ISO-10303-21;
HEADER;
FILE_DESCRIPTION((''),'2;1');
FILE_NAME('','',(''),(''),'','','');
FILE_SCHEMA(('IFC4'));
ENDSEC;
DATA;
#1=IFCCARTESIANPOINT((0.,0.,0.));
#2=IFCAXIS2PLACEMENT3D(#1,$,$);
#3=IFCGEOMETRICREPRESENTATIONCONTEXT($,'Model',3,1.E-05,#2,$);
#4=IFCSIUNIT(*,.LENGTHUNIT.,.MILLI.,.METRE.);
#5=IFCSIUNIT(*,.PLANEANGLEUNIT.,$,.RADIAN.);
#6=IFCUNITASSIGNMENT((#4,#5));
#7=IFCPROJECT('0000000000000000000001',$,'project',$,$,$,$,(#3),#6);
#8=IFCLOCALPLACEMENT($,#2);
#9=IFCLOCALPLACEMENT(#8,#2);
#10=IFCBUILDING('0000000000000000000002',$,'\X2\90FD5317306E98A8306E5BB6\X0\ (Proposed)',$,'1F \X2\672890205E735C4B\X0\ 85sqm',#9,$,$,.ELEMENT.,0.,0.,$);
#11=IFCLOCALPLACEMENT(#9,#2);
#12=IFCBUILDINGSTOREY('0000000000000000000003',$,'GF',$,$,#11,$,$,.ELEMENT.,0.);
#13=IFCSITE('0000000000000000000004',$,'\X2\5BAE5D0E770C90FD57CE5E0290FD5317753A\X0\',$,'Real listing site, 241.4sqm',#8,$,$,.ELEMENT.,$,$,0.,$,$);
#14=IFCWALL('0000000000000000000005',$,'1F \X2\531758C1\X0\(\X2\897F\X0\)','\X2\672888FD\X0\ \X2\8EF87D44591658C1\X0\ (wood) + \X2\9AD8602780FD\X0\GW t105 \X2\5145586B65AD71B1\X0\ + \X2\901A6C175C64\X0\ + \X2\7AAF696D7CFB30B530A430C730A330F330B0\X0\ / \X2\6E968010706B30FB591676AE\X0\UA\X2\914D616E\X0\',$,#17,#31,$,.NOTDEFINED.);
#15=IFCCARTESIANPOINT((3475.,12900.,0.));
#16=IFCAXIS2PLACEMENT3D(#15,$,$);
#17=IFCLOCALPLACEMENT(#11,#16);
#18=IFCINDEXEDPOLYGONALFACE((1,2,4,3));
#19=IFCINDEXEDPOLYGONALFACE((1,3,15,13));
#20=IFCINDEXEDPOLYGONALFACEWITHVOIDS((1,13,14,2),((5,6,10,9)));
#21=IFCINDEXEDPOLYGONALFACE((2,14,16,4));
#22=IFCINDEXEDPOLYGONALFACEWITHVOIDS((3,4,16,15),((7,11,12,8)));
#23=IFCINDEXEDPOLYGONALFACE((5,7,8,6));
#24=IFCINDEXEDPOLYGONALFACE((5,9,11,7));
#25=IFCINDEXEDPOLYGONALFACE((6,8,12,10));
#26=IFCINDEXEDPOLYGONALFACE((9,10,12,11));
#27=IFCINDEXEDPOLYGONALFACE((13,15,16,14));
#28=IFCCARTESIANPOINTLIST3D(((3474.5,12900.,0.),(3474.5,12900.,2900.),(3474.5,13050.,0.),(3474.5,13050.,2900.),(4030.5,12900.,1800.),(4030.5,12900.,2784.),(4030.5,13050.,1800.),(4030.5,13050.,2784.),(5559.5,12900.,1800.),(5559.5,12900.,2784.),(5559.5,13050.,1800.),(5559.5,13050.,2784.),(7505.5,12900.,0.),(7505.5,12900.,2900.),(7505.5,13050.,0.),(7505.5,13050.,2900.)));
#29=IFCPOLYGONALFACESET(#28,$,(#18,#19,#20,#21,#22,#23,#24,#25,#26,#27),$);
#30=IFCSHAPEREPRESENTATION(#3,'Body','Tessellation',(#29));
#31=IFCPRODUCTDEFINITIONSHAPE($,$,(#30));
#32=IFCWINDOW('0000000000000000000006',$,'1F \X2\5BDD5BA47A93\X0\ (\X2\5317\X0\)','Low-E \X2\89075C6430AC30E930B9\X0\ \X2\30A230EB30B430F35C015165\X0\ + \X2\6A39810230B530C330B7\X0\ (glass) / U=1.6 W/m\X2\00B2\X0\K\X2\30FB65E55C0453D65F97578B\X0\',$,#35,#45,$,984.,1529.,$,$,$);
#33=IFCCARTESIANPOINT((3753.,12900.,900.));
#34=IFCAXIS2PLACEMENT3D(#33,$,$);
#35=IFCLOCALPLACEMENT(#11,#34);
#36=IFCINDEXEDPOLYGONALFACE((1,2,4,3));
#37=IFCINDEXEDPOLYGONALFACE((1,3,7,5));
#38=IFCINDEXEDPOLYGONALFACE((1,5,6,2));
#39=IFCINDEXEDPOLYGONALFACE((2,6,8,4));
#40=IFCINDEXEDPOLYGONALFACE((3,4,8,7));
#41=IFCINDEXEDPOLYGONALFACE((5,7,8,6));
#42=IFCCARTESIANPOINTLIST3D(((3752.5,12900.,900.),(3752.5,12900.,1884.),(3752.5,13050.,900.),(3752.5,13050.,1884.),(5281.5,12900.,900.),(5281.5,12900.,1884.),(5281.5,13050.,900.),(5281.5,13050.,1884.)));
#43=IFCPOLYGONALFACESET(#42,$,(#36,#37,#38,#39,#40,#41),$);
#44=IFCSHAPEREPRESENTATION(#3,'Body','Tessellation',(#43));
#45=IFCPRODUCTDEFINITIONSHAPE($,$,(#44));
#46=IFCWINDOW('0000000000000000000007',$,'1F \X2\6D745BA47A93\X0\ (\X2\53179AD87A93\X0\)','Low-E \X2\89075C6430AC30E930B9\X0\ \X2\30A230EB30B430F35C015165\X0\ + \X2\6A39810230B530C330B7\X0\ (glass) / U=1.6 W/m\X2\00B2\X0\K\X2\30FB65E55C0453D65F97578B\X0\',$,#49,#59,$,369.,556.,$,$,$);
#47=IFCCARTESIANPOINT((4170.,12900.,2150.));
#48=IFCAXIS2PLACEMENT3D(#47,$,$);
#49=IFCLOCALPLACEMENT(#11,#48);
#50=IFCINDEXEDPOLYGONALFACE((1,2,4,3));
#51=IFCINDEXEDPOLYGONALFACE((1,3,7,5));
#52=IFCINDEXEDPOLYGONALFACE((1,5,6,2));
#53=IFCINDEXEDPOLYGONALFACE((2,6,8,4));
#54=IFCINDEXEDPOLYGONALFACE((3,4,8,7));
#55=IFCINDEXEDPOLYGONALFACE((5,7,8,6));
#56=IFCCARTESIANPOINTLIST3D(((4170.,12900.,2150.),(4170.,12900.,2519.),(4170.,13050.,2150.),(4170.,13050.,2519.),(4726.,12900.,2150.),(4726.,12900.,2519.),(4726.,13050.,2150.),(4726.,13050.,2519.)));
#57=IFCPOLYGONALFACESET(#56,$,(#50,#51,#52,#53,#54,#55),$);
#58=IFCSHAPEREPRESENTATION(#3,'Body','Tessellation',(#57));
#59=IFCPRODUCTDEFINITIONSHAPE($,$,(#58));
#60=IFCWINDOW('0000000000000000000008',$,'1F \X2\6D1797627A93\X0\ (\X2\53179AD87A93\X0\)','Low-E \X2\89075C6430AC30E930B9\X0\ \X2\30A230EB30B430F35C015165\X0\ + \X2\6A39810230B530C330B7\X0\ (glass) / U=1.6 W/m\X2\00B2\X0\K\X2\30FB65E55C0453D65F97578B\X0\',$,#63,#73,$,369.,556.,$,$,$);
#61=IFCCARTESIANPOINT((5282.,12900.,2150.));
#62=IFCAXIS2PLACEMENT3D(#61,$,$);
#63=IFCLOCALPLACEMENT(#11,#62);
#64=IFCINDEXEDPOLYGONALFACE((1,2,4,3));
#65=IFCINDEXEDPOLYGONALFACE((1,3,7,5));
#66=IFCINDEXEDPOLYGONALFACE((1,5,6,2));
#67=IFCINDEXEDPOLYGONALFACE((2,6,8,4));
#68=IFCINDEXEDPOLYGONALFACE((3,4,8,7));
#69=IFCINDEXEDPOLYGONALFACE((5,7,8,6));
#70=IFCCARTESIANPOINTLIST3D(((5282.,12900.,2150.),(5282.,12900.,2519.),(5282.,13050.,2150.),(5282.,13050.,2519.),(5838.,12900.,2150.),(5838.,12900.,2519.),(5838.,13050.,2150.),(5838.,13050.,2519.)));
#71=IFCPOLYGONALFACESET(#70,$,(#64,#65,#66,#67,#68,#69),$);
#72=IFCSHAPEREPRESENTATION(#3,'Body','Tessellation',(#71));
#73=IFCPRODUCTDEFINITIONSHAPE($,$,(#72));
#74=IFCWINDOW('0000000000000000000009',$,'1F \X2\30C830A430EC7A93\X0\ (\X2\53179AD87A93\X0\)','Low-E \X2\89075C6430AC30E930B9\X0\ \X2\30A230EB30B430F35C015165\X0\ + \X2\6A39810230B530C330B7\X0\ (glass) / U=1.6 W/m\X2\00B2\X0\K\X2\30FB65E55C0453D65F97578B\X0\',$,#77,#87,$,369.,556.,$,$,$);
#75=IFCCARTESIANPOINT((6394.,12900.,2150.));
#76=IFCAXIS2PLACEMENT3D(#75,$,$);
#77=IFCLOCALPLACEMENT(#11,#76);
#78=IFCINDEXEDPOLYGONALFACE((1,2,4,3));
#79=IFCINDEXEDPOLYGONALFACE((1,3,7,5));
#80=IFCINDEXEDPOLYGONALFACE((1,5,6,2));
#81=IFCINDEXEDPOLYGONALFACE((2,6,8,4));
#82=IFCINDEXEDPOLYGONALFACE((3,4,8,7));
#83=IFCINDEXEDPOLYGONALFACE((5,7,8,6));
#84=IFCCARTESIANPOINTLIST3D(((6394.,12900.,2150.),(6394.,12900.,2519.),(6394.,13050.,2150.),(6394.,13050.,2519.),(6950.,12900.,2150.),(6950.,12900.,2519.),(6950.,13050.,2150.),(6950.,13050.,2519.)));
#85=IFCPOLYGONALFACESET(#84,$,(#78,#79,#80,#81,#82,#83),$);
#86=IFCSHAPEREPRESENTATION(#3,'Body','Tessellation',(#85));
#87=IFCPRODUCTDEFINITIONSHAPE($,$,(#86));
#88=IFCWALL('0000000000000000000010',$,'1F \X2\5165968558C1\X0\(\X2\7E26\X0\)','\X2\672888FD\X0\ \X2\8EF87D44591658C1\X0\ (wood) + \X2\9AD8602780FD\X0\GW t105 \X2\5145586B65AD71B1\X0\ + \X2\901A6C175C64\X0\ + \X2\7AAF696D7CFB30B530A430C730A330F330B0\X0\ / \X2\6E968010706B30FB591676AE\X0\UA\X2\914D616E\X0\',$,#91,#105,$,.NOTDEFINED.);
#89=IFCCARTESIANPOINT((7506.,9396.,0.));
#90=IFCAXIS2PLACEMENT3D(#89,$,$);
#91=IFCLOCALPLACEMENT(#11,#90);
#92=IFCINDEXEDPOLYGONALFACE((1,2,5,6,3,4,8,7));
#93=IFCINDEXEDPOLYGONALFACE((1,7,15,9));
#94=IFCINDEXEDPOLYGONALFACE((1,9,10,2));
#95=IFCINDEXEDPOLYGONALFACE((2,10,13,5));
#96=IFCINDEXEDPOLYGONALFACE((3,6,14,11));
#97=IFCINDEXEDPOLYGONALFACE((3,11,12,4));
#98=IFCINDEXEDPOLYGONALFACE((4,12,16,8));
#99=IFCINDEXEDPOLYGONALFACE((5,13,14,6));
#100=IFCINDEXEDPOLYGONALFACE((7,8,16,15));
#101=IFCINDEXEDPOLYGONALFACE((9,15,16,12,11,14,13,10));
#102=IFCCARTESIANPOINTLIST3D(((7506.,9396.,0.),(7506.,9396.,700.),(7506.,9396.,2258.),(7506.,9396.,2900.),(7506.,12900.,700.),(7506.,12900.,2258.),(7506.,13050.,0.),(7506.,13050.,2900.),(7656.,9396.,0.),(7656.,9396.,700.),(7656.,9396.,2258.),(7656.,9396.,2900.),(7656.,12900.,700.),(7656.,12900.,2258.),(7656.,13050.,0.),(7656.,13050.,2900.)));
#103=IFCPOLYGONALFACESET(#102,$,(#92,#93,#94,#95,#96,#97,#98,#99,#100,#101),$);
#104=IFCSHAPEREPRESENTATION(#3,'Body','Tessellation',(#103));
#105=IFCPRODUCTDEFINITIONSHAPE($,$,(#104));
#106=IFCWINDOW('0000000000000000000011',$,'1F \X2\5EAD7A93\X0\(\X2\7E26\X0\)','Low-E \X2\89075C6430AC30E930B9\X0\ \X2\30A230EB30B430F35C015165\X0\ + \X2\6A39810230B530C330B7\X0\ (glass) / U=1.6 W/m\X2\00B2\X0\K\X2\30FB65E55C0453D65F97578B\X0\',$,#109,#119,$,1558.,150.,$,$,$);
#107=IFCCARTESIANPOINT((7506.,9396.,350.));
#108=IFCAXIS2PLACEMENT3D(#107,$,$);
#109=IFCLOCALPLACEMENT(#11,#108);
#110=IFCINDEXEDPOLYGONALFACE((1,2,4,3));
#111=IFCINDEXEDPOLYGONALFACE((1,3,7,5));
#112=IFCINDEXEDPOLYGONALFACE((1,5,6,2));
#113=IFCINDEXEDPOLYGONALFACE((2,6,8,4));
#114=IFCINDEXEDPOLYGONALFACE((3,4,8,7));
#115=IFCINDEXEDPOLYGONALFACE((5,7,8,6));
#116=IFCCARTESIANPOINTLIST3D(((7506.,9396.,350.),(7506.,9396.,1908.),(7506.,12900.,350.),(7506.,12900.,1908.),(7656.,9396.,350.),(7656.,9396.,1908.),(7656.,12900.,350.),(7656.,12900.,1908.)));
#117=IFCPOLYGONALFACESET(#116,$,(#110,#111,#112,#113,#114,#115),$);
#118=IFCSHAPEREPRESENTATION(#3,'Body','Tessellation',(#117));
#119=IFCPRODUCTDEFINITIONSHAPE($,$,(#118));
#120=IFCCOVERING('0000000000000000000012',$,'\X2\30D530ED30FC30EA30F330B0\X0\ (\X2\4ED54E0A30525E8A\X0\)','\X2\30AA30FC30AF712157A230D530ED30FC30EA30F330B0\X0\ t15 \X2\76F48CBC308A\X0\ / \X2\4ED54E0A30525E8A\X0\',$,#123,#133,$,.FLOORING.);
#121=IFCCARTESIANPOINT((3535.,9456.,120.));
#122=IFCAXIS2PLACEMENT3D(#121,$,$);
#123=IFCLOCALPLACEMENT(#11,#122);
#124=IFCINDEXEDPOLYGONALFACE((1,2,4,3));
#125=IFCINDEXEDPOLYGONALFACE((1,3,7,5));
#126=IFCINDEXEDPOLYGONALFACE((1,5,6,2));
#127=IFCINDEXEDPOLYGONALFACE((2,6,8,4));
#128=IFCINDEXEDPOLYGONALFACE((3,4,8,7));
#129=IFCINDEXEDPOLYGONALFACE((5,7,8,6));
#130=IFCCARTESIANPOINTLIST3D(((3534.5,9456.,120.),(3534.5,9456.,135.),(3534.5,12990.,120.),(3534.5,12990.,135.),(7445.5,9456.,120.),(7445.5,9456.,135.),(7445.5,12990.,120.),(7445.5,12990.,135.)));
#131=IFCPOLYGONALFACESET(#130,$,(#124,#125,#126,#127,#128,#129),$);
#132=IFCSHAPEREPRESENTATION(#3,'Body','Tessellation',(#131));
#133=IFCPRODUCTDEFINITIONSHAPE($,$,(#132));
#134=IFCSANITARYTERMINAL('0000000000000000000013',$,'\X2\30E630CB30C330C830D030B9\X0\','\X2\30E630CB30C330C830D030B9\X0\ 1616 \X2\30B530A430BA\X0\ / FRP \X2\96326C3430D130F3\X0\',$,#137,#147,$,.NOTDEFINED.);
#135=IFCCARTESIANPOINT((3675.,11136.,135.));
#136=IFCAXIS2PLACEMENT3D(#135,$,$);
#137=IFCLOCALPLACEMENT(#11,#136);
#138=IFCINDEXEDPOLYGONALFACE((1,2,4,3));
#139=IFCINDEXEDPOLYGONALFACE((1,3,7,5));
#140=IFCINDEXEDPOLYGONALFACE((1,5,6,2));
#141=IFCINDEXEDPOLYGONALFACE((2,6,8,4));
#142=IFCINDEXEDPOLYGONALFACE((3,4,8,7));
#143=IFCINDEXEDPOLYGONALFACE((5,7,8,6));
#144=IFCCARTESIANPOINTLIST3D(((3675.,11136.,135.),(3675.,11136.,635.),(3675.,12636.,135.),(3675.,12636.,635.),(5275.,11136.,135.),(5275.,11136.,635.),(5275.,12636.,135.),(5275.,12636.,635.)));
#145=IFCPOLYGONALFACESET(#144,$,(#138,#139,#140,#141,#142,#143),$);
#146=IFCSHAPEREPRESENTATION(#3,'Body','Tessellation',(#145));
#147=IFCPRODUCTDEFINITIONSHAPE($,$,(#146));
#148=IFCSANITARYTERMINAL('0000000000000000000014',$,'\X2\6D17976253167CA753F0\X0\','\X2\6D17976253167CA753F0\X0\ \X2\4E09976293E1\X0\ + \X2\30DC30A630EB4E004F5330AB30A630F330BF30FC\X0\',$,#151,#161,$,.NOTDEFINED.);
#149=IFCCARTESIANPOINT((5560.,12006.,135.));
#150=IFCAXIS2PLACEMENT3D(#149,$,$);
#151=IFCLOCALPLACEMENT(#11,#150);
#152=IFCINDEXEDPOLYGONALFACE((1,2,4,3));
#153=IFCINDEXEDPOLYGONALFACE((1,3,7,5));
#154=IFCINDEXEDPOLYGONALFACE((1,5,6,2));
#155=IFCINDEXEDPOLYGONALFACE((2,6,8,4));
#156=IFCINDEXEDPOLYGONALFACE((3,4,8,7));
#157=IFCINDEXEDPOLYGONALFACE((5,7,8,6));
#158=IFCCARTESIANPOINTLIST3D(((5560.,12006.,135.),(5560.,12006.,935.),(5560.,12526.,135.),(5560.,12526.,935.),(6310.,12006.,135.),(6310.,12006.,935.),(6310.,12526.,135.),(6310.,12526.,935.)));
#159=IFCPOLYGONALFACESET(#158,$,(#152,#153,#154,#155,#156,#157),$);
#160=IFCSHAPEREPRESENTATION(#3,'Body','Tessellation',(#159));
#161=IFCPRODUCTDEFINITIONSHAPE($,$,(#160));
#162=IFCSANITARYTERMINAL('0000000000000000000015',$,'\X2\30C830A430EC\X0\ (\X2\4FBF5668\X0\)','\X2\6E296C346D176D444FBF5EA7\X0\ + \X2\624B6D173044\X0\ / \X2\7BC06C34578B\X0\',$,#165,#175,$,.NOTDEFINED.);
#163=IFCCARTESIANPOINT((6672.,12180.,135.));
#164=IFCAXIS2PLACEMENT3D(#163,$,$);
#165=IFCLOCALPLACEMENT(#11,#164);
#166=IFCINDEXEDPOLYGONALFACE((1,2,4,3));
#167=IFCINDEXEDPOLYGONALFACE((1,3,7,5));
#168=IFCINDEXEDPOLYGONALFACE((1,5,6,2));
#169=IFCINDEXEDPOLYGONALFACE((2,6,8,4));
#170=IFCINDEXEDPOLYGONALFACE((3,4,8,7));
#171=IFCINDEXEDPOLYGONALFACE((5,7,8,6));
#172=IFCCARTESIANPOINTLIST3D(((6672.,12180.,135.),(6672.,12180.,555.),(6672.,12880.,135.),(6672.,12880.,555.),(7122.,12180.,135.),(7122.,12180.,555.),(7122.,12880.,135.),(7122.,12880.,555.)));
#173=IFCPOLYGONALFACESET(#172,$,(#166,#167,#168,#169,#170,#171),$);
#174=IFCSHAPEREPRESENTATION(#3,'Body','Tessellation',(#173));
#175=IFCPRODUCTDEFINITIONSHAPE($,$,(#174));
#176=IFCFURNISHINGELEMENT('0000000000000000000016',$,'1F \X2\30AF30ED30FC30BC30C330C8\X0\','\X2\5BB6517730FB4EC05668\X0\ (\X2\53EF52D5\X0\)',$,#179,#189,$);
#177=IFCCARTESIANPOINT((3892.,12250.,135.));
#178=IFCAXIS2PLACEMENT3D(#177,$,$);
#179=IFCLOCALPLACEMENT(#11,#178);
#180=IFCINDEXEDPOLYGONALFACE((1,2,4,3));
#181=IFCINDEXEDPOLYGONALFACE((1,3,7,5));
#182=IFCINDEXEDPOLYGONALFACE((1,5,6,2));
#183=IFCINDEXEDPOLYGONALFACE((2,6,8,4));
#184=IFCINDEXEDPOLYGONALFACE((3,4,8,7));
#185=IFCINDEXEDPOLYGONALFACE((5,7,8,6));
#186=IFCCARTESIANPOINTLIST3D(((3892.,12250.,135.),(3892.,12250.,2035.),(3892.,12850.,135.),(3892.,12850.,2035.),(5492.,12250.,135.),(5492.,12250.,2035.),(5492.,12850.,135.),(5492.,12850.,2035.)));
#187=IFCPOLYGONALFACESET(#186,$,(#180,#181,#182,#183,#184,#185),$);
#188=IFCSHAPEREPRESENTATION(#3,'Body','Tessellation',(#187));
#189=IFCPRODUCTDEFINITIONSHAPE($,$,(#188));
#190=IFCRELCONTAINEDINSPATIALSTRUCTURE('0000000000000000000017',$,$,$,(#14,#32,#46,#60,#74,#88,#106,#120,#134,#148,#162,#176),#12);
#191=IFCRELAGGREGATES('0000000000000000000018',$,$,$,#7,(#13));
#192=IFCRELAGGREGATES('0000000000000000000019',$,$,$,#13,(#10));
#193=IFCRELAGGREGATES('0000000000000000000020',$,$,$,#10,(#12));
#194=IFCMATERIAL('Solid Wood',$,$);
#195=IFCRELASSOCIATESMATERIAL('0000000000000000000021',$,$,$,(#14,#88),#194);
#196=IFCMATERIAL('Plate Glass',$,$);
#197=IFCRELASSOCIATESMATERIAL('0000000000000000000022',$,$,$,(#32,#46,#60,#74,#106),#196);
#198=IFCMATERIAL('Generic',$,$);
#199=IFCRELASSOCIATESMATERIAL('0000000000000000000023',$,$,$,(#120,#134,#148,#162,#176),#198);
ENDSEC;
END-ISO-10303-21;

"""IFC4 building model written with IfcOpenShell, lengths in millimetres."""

from ifc_helpers import new_model, si_unit, frame, frame_2d, origin, place, context, project, spatial, rectangle, extrude, material, element, fill, save


model = new_model("IFC4")

# Units and contexts
model_context = context("Model", 3, precision=1e-05, world=origin())
ifc_project = project(units=[si_unit("LENGTHUNIT", "METRE", prefix="MILLI"), si_unit("PLANEANGLEUNIT", "RADIAN")], contexts=[model_context])

# Site, building, storey
site_placement = place(None, origin())
site = spatial("IfcSite", under=ifc_project, at=site_placement, Name="宮崎県都城市都北町", ObjectType="Real listing site, 241.4sqm", CompositionType="ELEMENT", RefElevation=0.0)
building_placement = place(site_placement, origin())
building = spatial("IfcBuilding", under=site, at=building_placement, Name="都北の風の家 (Proposed)", ObjectType="1F 木造平屋 85sqm", CompositionType="ELEMENT", ElevationOfRefHeight=0.0, ElevationOfTerrain=0.0)
storey_placement = place(building_placement, origin())
storey = spatial("IfcBuildingStorey", under=building, at=storey_placement, Name="GF", CompositionType="ELEMENT", Elevation=0.0)

# Shared definitions
ifc_material_1 = material(Name="Solid Wood")

# Wall, openings, windows
wall_1_placement = place(storey_placement, frame((3475.0, 12900.0, 0.0)))
wall_1 = element("IfcWall", 1, at=wall_1_placement, inside=storey, material=ifc_material_1, Name="1F 北壁(西)", Description="木製 軸組外壁 (wood) + 高性能GW t105 充填断熱 + 通気層 + 窯業系サイディング / 準耐火・外皮UA配慮", PredefinedType="NOTDEFINED", context=model_context, shape_type="SweptSolid", body=[
    extrude(rectangle(XDim=4031.0, YDim=150.0, at=frame_2d((2015.0, 75.0))), frame((3475.0, 12900.0, 0.0)), (0.0, 0.0, 1.0), 2900.0),
])
opening_1_placement = place(storey_placement, frame((3753.0, 12900.0, 900.0)))
opening_1 = element("IfcOpeningElement", 2, at=opening_1_placement, cuts=wall_1, PredefinedType="NOTDEFINED", context=model_context, shape_type="SweptSolid", body=[
    extrude(rectangle(XDim=1529.0, YDim=150.0, at=frame_2d((764.0, 75.0))), frame((3753.0, 12900.0, 900.0)), (0.0, 0.0, 1.0), 984.0),
])
opening_2_placement = place(storey_placement, frame((4170.0, 12900.0, 2150.0)))
opening_2 = element("IfcOpeningElement", 3, at=opening_2_placement, cuts=wall_1, PredefinedType="NOTDEFINED", context=model_context, shape_type="SweptSolid", body=[
    extrude(rectangle(XDim=556.0, YDim=150.0, at=frame_2d((278.0, 75.0))), frame((4170.0, 12900.0, 2150.0)), (0.0, 0.0, 1.0), 369.0),
])
opening_3_placement = place(storey_placement, frame((5282.0, 12900.0, 2150.0)))
opening_3 = element("IfcOpeningElement", 4, at=opening_3_placement, cuts=wall_1, PredefinedType="NOTDEFINED", context=model_context, shape_type="SweptSolid", body=[
    extrude(rectangle(XDim=556.0, YDim=150.0, at=frame_2d((278.0, 75.0))), frame((5282.0, 12900.0, 2150.0)), (0.0, 0.0, 1.0), 369.0),
])
opening_4_placement = place(storey_placement, frame((6394.0, 12900.0, 2150.0)))
opening_4 = element("IfcOpeningElement", 5, at=opening_4_placement, cuts=wall_1, PredefinedType="NOTDEFINED", context=model_context, shape_type="SweptSolid", body=[
    extrude(rectangle(XDim=556.0, YDim=150.0, at=frame_2d((278.0, 75.0))), frame((6394.0, 12900.0, 2150.0)), (0.0, 0.0, 1.0), 369.0),
])
ifc_material_2 = material(Name="Plate Glass")
window_1_placement = place(storey_placement, frame((3753.0, 12900.0, 900.0)))
window_1 = element("IfcWindow", 6, at=window_1_placement, inside=storey, material=ifc_material_2, Name="1F 寝室窓 (北)", Description="Low-E 複層ガラス アルゴン封入 + 樹脂サッシ (glass) / U=1.6 W/m²K・日射取得型", OverallHeight=984.0, OverallWidth=1529.0, context=model_context, shape_type="SweptSolid", body=[
    extrude(rectangle(XDim=1529.0, YDim=150.0, at=frame_2d((764.0, 75.0))), frame((3753.0, 12900.0, 900.0)), (0.0, 0.0, 1.0), 984.0),
])
fill(opening_1, window_1)
window_2_placement = place(storey_placement, frame((4170.0, 12900.0, 2150.0)))
window_2 = element("IfcWindow", 7, at=window_2_placement, inside=storey, material=ifc_material_2, Name="1F 浴室窓 (北高窓)", Description="Low-E 複層ガラス アルゴン封入 + 樹脂サッシ (glass) / U=1.6 W/m²K・日射取得型", OverallHeight=369.0, OverallWidth=556.0, context=model_context, shape_type="SweptSolid", body=[
    extrude(rectangle(XDim=556.0, YDim=150.0, at=frame_2d((278.0, 75.0))), frame((4170.0, 12900.0, 2150.0)), (0.0, 0.0, 1.0), 369.0),
])
fill(opening_2, window_2)
window_3_placement = place(storey_placement, frame((5282.0, 12900.0, 2150.0)))
window_3 = element("IfcWindow", 8, at=window_3_placement, inside=storey, material=ifc_material_2, Name="1F 洗面窓 (北高窓)", Description="Low-E 複層ガラス アルゴン封入 + 樹脂サッシ (glass) / U=1.6 W/m²K・日射取得型", OverallHeight=369.0, OverallWidth=556.0, context=model_context, shape_type="SweptSolid", body=[
    extrude(rectangle(XDim=556.0, YDim=150.0, at=frame_2d((278.0, 75.0))), frame((5282.0, 12900.0, 2150.0)), (0.0, 0.0, 1.0), 369.0),
])
fill(opening_3, window_3)
window_4_placement = place(storey_placement, frame((6394.0, 12900.0, 2150.0)))
window_4 = element("IfcWindow", 9, at=window_4_placement, inside=storey, material=ifc_material_2, Name="1F トイレ窓 (北高窓)", Description="Low-E 複層ガラス アルゴン封入 + 樹脂サッシ (glass) / U=1.6 W/m²K・日射取得型", OverallHeight=369.0, OverallWidth=556.0, context=model_context, shape_type="SweptSolid", body=[
    extrude(rectangle(XDim=556.0, YDim=150.0, at=frame_2d((278.0, 75.0))), frame((6394.0, 12900.0, 2150.0)), (0.0, 0.0, 1.0), 369.0),
])
fill(opening_4, window_4)

# Wall, opening, window
wall_2_placement = place(storey_placement, frame((7506.0, 9396.0, 0.0)))
wall_2 = element("IfcWall", 10, at=wall_2_placement, inside=storey, material=ifc_material_1, Name="1F 入隅壁(縦)", Description="木製 軸組外壁 (wood) + 高性能GW t105 充填断熱 + 通気層 + 窯業系サイディング / 準耐火・外皮UA配慮", PredefinedType="NOTDEFINED", context=model_context, shape_type="SweptSolid", body=[
    extrude(rectangle(XDim=150.0, YDim=3654.0, at=frame_2d((75.0, 1827.0))), frame((7506.0, 9396.0, 0.0)), (0.0, 0.0, 1.0), 2900.0),
])
opening_5_placement = place(storey_placement, frame((7506.0, 9396.0, 350.0)))
opening_5 = element("IfcOpeningElement", 11, at=opening_5_placement, cuts=wall_2, PredefinedType="NOTDEFINED", context=model_context, shape_type="SweptSolid", body=[
    extrude(rectangle(XDim=150.0, YDim=3504.0, at=frame_2d((75.0, 1752.0))), frame((7506.0, 9396.0, 350.0)), (0.0, 0.0, 1.0), 1558.0),
])
window_5_placement = place(storey_placement, frame((7506.0, 9396.0, 350.0)))
window_5 = element("IfcWindow", 12, at=window_5_placement, inside=storey, material=ifc_material_2, Name="1F 庭窓(縦)", Description="Low-E 複層ガラス アルゴン封入 + 樹脂サッシ (glass) / U=1.6 W/m²K・日射取得型", OverallHeight=1558.0, OverallWidth=150.0, context=model_context, shape_type="SweptSolid", body=[
    extrude(rectangle(XDim=150.0, YDim=3504.0, at=frame_2d((75.0, 1752.0))), frame((7506.0, 9396.0, 350.0)), (0.0, 0.0, 1.0), 1558.0),
])
fill(opening_5, window_5)

# Covering
ifc_material_3 = material(Name="Generic")
covering_placement = place(storey_placement, frame((3535.0, 9456.0, 120.0)))
element("IfcCovering", 13, at=covering_placement, inside=storey, material=ifc_material_3, Name="フローリング (仕上げ床)", Description="オーク無垢フローリング t15 直貼り / 仕上げ床", PredefinedType="FLOORING", context=model_context, shape_type="SweptSolid", body=[
    extrude(rectangle(XDim=3911.0, YDim=3534.0, at=frame_2d((1955.0, 1767.0))), frame((3535.0, 9456.0, 120.0)), (0.0, 0.0, 1.0), 15.0),
])

# Sanitary terminals
sanitary_terminal_1_placement = place(storey_placement, frame((3675.0, 11136.0, 135.0)))
element("IfcSanitaryTerminal", 14, at=sanitary_terminal_1_placement, inside=storey, material=ifc_material_3, Name="ユニットバス", Description="ユニットバス 1616 サイズ / FRP 防水パン", PredefinedType="NOTDEFINED", context=model_context, shape_type="SweptSolid", body=[
    extrude(rectangle(XDim=1600.0, YDim=1500.0, at=frame_2d((800.0, 750.0))), frame((3675.0, 11136.0, 135.0)), (0.0, 0.0, 1.0), 500.0),
])
sanitary_terminal_2_placement = place(storey_placement, frame((5560.0, 12006.0, 135.0)))
element("IfcSanitaryTerminal", 15, at=sanitary_terminal_2_placement, inside=storey, material=ifc_material_3, Name="洗面化粧台", Description="洗面化粧台 三面鏡 + ボウル一体カウンター", PredefinedType="NOTDEFINED", context=model_context, shape_type="SweptSolid", body=[
    extrude(rectangle(XDim=750.0, YDim=520.0, at=frame_2d((375.0, 260.0))), frame((5560.0, 12006.0, 135.0)), (0.0, 0.0, 1.0), 800.0),
])
sanitary_terminal_3_placement = place(storey_placement, frame((6672.0, 12180.0, 135.0)))
element("IfcSanitaryTerminal", 16, at=sanitary_terminal_3_placement, inside=storey, material=ifc_material_3, Name="トイレ (便器)", Description="温水洗浄便座 + 手洗い / 節水型", PredefinedType="NOTDEFINED", context=model_context, shape_type="SweptSolid", body=[
    extrude(rectangle(XDim=450.0, YDim=700.0, at=frame_2d((225.0, 350.0))), frame((6672.0, 12180.0, 135.0)), (0.0, 0.0, 1.0), 420.0),
])

# Furnishing element
furnishing_1_placement = place(storey_placement, frame((3892.0, 12250.0, 135.0)))
element("IfcFurnishingElement", 17, at=furnishing_1_placement, inside=storey, material=ifc_material_3, Name="1F クローゼット", Description="家具・什器 (可動)", context=model_context, shape_type="SweptSolid", body=[
    extrude(rectangle(XDim=1600.0, YDim=600.0, at=frame_2d((800.0, 300.0))), frame((3892.0, 12250.0, 135.0)), (0.0, 0.0, 1.0), 1900.0),
])

save(model, "model.ifc")
